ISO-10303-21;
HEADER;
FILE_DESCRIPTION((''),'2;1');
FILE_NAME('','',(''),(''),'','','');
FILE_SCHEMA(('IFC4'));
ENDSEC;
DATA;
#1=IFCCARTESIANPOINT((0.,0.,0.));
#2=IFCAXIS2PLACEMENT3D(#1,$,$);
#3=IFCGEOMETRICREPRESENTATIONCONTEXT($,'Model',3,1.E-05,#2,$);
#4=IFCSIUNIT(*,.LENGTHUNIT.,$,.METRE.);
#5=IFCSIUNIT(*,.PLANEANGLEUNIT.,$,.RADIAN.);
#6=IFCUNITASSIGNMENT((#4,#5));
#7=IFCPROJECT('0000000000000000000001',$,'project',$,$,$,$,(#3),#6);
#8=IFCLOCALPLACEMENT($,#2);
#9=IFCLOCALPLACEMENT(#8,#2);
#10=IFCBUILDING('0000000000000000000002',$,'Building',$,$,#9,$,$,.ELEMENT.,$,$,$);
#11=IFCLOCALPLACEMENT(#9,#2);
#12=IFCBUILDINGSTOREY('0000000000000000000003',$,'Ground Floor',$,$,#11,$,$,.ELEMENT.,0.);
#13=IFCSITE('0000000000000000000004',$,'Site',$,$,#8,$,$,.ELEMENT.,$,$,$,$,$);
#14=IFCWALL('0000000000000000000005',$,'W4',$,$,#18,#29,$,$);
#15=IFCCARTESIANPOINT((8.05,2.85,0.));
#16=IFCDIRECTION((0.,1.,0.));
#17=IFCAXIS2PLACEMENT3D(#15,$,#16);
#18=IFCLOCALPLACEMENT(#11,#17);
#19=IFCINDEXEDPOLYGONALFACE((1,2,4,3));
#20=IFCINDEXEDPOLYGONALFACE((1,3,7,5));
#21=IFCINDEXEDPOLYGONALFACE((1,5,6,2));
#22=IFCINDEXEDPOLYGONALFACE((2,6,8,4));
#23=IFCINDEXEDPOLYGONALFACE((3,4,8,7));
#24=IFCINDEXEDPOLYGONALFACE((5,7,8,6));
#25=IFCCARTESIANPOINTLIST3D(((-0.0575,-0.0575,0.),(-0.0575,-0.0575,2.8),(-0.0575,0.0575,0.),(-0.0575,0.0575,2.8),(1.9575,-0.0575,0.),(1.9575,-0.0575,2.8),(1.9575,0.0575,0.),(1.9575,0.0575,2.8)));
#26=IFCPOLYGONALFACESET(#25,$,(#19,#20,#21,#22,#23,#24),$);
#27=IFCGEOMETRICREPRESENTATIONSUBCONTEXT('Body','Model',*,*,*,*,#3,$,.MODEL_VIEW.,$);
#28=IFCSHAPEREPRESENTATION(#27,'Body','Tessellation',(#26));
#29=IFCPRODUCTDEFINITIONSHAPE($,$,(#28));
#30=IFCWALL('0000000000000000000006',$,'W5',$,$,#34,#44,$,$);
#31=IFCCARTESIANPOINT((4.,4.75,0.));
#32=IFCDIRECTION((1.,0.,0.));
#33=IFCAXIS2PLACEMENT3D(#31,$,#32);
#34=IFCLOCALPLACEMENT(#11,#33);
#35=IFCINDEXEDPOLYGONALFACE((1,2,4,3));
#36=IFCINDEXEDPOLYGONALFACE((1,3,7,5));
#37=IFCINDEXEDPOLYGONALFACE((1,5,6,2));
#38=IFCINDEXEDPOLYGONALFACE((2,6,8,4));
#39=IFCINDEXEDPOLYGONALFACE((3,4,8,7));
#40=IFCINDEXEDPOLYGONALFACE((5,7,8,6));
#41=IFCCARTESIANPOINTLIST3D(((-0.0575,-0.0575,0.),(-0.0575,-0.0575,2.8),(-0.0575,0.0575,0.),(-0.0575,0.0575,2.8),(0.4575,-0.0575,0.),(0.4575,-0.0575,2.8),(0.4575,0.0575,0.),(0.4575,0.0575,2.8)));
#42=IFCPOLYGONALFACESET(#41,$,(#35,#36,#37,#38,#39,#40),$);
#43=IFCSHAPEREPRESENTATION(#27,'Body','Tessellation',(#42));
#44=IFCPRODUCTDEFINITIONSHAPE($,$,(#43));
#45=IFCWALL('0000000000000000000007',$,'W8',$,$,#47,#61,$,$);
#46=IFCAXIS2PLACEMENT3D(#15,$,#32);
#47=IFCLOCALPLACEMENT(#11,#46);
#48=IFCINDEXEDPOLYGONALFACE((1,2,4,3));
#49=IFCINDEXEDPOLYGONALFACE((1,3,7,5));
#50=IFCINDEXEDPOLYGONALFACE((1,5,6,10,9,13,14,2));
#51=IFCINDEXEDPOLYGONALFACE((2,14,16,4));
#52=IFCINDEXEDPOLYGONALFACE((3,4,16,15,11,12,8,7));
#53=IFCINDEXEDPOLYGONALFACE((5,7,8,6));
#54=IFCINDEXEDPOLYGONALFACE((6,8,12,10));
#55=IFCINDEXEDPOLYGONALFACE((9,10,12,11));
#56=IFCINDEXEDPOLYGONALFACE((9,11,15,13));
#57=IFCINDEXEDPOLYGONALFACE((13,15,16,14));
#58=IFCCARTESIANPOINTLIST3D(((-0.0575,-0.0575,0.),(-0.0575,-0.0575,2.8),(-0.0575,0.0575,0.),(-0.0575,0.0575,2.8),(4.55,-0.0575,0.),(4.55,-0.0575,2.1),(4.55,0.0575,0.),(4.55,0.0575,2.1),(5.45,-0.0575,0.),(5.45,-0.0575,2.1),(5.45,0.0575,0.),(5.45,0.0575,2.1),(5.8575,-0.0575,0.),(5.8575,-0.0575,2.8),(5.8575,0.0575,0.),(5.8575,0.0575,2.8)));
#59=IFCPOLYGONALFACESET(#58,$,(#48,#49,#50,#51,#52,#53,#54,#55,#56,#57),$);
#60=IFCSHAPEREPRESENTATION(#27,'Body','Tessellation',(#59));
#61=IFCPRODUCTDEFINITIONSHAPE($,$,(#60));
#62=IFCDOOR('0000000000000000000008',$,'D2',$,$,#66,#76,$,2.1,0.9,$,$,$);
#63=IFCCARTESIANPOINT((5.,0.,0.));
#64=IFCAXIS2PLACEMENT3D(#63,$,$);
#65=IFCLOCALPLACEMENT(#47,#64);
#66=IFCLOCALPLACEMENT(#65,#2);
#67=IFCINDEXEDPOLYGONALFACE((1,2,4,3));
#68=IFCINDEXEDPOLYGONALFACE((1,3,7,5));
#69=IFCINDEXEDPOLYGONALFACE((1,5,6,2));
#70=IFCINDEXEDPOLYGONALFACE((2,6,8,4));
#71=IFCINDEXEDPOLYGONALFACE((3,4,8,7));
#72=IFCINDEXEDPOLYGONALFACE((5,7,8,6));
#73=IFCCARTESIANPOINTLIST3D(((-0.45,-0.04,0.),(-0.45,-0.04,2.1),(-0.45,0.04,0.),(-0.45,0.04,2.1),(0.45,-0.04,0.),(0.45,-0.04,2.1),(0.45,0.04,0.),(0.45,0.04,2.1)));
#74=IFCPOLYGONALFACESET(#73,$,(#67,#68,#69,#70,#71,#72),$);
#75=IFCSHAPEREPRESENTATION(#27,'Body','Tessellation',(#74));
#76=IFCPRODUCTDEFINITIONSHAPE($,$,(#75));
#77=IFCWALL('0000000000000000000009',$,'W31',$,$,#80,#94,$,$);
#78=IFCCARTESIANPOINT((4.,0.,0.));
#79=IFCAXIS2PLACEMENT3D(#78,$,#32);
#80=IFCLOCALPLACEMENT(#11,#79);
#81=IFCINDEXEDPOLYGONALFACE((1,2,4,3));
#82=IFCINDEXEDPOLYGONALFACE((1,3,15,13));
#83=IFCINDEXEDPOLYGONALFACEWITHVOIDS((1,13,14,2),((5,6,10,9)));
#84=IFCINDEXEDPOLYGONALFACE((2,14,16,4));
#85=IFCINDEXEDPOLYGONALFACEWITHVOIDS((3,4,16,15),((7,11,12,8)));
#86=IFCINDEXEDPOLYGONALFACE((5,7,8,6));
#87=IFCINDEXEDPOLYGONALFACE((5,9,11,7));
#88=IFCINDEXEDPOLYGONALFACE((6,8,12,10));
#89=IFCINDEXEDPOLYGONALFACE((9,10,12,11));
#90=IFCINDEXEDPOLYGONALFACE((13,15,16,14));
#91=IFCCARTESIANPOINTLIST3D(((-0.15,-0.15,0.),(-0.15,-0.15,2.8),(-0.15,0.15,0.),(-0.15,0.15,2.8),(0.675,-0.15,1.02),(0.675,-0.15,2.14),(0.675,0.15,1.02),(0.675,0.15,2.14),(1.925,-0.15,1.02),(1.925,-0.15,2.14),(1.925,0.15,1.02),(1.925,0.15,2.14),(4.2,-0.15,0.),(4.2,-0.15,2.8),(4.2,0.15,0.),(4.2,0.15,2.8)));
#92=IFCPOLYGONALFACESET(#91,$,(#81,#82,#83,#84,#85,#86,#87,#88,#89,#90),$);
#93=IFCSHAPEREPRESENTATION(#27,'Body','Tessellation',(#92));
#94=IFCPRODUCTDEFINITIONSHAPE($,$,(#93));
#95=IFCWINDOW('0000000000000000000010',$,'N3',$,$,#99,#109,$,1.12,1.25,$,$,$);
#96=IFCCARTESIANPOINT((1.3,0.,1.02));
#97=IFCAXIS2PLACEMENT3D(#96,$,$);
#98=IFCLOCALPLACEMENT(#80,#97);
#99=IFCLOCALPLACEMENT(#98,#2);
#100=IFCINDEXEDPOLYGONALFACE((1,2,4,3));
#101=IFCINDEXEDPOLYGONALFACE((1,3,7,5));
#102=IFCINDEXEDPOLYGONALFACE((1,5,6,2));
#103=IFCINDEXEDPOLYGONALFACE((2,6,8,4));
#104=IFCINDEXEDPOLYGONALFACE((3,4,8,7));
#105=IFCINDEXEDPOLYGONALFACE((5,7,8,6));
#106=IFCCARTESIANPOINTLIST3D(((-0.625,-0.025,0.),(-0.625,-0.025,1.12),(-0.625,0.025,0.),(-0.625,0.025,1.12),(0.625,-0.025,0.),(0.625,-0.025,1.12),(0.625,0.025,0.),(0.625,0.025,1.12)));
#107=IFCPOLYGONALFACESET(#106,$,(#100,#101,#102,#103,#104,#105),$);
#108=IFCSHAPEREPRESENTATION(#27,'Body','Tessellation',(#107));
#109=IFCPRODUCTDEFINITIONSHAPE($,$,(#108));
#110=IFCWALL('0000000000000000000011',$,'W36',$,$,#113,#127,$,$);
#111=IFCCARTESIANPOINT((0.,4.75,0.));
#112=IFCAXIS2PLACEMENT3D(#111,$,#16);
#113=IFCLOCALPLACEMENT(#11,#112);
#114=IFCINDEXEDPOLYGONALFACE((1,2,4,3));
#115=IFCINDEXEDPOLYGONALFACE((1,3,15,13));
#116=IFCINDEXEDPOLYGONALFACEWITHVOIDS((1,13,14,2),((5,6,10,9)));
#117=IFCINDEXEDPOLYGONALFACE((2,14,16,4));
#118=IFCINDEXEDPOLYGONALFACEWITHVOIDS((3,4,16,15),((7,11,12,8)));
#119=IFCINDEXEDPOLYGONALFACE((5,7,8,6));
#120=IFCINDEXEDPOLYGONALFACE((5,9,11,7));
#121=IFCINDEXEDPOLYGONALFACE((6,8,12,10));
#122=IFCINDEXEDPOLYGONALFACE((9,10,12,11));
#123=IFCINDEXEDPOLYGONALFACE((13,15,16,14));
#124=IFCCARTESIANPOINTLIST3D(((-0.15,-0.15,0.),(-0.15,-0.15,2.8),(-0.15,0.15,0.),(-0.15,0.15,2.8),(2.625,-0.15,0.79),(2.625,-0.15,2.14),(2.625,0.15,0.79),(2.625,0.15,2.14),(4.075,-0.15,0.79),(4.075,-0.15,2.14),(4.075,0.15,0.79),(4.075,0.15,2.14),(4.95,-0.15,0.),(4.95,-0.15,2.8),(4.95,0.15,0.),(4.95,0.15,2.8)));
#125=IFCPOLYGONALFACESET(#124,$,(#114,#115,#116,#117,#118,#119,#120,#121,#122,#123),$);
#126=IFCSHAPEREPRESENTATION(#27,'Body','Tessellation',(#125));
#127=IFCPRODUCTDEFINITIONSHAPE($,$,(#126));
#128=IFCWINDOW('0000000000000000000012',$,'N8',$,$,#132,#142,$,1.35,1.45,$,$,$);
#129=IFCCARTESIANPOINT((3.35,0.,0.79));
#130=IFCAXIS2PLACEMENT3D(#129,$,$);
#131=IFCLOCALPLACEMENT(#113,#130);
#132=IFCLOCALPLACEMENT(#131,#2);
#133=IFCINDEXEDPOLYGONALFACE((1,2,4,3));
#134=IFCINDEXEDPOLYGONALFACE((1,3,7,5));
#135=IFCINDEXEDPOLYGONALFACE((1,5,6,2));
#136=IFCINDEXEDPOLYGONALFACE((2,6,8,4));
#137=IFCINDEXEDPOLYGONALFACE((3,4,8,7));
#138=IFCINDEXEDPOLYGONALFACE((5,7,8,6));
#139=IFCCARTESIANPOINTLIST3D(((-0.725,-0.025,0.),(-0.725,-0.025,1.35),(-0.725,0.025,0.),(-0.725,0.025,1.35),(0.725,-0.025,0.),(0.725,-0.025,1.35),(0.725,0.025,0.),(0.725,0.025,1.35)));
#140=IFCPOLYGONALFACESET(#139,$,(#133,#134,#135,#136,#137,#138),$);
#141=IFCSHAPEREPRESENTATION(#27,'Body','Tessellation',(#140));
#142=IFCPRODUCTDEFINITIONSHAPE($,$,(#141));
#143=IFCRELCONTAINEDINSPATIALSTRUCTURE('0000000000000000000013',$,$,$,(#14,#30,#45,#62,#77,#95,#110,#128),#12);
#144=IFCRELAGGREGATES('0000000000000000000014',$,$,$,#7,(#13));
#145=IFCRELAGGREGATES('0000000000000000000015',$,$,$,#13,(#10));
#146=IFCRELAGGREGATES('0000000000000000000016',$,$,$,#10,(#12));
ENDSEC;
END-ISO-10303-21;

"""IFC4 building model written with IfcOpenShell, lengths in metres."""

from ifc_helpers import new_model, si_unit, frame, frame_2d, origin, origin_2d, place, context, subcontext, project, spatial, rectangle, extrude, element, fill, save


model = new_model("IFC4")

# Units and contexts
model_context = context("Model", 3, precision=1e-05, world=origin())
body_context = subcontext(model_context, "Body", "Model", "MODEL_VIEW")
ifc_project = project(units=[si_unit("LENGTHUNIT", "METRE"), si_unit("PLANEANGLEUNIT", "RADIAN")], contexts=[model_context])

# Site, building, storey
site_placement = place(None, origin())
site = spatial("IfcSite", under=ifc_project, at=site_placement, Name="Site", CompositionType="ELEMENT")
building_placement = place(site_placement, origin())
building = spatial("IfcBuilding", under=site, at=building_placement, Name="Building", CompositionType="ELEMENT")
storey_placement = place(building_placement, origin())
storey = spatial("IfcBuildingStorey", under=building, at=storey_placement, Name="Ground Floor", CompositionType="ELEMENT", Elevation=0.0)

# Walls
wall_1_placement = place(storey_placement, frame((8.05, 2.85, 0.0), x_axis=(0.0, 1.0, 0.0)))
element("IfcWall", 1, at=wall_1_placement, inside=storey, Name="W4", context=body_context, shape_type="SweptSolid", body=[
    extrude(rectangle(XDim=2.015, YDim=0.115, at=frame_2d((0.95, 0.0))), origin(), (0.0, 0.0, 1.0), 2.8),
])
wall_2_placement = place(storey_placement, frame((4.0, 4.75, 0.0), x_axis=(1.0, 0.0, 0.0)))
element("IfcWall", 2, at=wall_2_placement, inside=storey, Name="W5", context=body_context, shape_type="SweptSolid", body=[
    extrude(rectangle(XDim=0.515, YDim=0.115, at=frame_2d((0.2, 0.0))), origin(), (0.0, 0.0, 1.0), 2.8),
])

# Wall, opening, door
wall_3_placement = place(storey_placement, frame((8.05, 2.85, 0.0), x_axis=(1.0, 0.0, 0.0)))
wall_3 = element("IfcWall", 3, at=wall_3_placement, inside=storey, Name="W8", context=body_context, shape_type="SweptSolid", body=[
    extrude(rectangle(XDim=5.915, YDim=0.115, at=frame_2d((2.9, 0.0))), origin(), (0.0, 0.0, 1.0), 2.8),
])
opening_1_placement = place(wall_3_placement, frame((5.0, 0.0, 0.0)))
opening_1 = element("IfcOpeningElement", 4, at=opening_1_placement, cuts=wall_3, context=body_context, shape_type="SweptSolid", body=[
    extrude(rectangle(XDim=0.9, YDim=0.215, at=origin_2d()), origin(), (0.0, 0.0, 1.0), 2.1),
])
door_1_placement = place(opening_1_placement, origin())
door_1 = element("IfcDoor", 5, at=door_1_placement, inside=storey, Name="D2", OverallHeight=2.1, OverallWidth=0.9, context=body_context, shape_type="SweptSolid", body=[
    extrude(rectangle(XDim=0.9, YDim=0.08, at=origin_2d()), origin(), (0.0, 0.0, 1.0), 2.1),
])
fill(opening_1, door_1)

# Walls, openings, windows
wall_4_placement = place(storey_placement, frame((4.0, 0.0, 0.0), x_axis=(1.0, 0.0, 0.0)))
wall_4 = element("IfcWall", 6, at=wall_4_placement, inside=storey, Name="W31", context=body_context, shape_type="SweptSolid", body=[
    extrude(rectangle(XDim=4.35, YDim=0.3, at=frame_2d((2.025, 0.0))), origin(), (0.0, 0.0, 1.0), 2.8),
])
opening_2_placement = place(wall_4_placement, frame((1.3, 0.0, 1.02)))
opening_2 = element("IfcOpeningElement", 7, at=opening_2_placement, cuts=wall_4, context=body_context, shape_type="SweptSolid", body=[
    extrude(rectangle(XDim=1.25, YDim=0.4, at=origin_2d()), origin(), (0.0, 0.0, 1.0), 1.12),
])
window_1_placement = place(opening_2_placement, origin())
window_1 = element("IfcWindow", 8, at=window_1_placement, inside=storey, Name="N3", OverallHeight=1.12, OverallWidth=1.25, context=body_context, shape_type="SweptSolid", body=[
    extrude(rectangle(XDim=1.25, YDim=0.05, at=origin_2d()), origin(), (0.0, 0.0, 1.0), 1.12),
])
fill(opening_2, window_1)
wall_5_placement = place(storey_placement, frame((0.0, 4.75, 0.0), x_axis=(0.0, 1.0, 0.0)))
wall_5 = element("IfcWall", 9, at=wall_5_placement, inside=storey, Name="W36", context=body_context, shape_type="SweptSolid", body=[
    extrude(rectangle(XDim=5.1, YDim=0.3, at=frame_2d((2.4, 0.0))), origin(), (0.0, 0.0, 1.0), 2.8),
])
opening_3_placement = place(wall_5_placement, frame((3.35, 0.0, 0.79)))
opening_3 = element("IfcOpeningElement", 10, at=opening_3_placement, cuts=wall_5, context=body_context, shape_type="SweptSolid", body=[
    extrude(rectangle(XDim=1.45, YDim=0.4, at=origin_2d()), origin(), (0.0, 0.0, 1.0), 1.35),
])
window_2_placement = place(opening_3_placement, origin())
window_2 = element("IfcWindow", 11, at=window_2_placement, inside=storey, Name="N8", OverallHeight=1.35, OverallWidth=1.45, context=body_context, shape_type="SweptSolid", body=[
    extrude(rectangle(XDim=1.45, YDim=0.05, at=origin_2d()), origin(), (0.0, 0.0, 1.0), 1.35),
])
fill(opening_3, window_2)

save(model, "model.ifc")
